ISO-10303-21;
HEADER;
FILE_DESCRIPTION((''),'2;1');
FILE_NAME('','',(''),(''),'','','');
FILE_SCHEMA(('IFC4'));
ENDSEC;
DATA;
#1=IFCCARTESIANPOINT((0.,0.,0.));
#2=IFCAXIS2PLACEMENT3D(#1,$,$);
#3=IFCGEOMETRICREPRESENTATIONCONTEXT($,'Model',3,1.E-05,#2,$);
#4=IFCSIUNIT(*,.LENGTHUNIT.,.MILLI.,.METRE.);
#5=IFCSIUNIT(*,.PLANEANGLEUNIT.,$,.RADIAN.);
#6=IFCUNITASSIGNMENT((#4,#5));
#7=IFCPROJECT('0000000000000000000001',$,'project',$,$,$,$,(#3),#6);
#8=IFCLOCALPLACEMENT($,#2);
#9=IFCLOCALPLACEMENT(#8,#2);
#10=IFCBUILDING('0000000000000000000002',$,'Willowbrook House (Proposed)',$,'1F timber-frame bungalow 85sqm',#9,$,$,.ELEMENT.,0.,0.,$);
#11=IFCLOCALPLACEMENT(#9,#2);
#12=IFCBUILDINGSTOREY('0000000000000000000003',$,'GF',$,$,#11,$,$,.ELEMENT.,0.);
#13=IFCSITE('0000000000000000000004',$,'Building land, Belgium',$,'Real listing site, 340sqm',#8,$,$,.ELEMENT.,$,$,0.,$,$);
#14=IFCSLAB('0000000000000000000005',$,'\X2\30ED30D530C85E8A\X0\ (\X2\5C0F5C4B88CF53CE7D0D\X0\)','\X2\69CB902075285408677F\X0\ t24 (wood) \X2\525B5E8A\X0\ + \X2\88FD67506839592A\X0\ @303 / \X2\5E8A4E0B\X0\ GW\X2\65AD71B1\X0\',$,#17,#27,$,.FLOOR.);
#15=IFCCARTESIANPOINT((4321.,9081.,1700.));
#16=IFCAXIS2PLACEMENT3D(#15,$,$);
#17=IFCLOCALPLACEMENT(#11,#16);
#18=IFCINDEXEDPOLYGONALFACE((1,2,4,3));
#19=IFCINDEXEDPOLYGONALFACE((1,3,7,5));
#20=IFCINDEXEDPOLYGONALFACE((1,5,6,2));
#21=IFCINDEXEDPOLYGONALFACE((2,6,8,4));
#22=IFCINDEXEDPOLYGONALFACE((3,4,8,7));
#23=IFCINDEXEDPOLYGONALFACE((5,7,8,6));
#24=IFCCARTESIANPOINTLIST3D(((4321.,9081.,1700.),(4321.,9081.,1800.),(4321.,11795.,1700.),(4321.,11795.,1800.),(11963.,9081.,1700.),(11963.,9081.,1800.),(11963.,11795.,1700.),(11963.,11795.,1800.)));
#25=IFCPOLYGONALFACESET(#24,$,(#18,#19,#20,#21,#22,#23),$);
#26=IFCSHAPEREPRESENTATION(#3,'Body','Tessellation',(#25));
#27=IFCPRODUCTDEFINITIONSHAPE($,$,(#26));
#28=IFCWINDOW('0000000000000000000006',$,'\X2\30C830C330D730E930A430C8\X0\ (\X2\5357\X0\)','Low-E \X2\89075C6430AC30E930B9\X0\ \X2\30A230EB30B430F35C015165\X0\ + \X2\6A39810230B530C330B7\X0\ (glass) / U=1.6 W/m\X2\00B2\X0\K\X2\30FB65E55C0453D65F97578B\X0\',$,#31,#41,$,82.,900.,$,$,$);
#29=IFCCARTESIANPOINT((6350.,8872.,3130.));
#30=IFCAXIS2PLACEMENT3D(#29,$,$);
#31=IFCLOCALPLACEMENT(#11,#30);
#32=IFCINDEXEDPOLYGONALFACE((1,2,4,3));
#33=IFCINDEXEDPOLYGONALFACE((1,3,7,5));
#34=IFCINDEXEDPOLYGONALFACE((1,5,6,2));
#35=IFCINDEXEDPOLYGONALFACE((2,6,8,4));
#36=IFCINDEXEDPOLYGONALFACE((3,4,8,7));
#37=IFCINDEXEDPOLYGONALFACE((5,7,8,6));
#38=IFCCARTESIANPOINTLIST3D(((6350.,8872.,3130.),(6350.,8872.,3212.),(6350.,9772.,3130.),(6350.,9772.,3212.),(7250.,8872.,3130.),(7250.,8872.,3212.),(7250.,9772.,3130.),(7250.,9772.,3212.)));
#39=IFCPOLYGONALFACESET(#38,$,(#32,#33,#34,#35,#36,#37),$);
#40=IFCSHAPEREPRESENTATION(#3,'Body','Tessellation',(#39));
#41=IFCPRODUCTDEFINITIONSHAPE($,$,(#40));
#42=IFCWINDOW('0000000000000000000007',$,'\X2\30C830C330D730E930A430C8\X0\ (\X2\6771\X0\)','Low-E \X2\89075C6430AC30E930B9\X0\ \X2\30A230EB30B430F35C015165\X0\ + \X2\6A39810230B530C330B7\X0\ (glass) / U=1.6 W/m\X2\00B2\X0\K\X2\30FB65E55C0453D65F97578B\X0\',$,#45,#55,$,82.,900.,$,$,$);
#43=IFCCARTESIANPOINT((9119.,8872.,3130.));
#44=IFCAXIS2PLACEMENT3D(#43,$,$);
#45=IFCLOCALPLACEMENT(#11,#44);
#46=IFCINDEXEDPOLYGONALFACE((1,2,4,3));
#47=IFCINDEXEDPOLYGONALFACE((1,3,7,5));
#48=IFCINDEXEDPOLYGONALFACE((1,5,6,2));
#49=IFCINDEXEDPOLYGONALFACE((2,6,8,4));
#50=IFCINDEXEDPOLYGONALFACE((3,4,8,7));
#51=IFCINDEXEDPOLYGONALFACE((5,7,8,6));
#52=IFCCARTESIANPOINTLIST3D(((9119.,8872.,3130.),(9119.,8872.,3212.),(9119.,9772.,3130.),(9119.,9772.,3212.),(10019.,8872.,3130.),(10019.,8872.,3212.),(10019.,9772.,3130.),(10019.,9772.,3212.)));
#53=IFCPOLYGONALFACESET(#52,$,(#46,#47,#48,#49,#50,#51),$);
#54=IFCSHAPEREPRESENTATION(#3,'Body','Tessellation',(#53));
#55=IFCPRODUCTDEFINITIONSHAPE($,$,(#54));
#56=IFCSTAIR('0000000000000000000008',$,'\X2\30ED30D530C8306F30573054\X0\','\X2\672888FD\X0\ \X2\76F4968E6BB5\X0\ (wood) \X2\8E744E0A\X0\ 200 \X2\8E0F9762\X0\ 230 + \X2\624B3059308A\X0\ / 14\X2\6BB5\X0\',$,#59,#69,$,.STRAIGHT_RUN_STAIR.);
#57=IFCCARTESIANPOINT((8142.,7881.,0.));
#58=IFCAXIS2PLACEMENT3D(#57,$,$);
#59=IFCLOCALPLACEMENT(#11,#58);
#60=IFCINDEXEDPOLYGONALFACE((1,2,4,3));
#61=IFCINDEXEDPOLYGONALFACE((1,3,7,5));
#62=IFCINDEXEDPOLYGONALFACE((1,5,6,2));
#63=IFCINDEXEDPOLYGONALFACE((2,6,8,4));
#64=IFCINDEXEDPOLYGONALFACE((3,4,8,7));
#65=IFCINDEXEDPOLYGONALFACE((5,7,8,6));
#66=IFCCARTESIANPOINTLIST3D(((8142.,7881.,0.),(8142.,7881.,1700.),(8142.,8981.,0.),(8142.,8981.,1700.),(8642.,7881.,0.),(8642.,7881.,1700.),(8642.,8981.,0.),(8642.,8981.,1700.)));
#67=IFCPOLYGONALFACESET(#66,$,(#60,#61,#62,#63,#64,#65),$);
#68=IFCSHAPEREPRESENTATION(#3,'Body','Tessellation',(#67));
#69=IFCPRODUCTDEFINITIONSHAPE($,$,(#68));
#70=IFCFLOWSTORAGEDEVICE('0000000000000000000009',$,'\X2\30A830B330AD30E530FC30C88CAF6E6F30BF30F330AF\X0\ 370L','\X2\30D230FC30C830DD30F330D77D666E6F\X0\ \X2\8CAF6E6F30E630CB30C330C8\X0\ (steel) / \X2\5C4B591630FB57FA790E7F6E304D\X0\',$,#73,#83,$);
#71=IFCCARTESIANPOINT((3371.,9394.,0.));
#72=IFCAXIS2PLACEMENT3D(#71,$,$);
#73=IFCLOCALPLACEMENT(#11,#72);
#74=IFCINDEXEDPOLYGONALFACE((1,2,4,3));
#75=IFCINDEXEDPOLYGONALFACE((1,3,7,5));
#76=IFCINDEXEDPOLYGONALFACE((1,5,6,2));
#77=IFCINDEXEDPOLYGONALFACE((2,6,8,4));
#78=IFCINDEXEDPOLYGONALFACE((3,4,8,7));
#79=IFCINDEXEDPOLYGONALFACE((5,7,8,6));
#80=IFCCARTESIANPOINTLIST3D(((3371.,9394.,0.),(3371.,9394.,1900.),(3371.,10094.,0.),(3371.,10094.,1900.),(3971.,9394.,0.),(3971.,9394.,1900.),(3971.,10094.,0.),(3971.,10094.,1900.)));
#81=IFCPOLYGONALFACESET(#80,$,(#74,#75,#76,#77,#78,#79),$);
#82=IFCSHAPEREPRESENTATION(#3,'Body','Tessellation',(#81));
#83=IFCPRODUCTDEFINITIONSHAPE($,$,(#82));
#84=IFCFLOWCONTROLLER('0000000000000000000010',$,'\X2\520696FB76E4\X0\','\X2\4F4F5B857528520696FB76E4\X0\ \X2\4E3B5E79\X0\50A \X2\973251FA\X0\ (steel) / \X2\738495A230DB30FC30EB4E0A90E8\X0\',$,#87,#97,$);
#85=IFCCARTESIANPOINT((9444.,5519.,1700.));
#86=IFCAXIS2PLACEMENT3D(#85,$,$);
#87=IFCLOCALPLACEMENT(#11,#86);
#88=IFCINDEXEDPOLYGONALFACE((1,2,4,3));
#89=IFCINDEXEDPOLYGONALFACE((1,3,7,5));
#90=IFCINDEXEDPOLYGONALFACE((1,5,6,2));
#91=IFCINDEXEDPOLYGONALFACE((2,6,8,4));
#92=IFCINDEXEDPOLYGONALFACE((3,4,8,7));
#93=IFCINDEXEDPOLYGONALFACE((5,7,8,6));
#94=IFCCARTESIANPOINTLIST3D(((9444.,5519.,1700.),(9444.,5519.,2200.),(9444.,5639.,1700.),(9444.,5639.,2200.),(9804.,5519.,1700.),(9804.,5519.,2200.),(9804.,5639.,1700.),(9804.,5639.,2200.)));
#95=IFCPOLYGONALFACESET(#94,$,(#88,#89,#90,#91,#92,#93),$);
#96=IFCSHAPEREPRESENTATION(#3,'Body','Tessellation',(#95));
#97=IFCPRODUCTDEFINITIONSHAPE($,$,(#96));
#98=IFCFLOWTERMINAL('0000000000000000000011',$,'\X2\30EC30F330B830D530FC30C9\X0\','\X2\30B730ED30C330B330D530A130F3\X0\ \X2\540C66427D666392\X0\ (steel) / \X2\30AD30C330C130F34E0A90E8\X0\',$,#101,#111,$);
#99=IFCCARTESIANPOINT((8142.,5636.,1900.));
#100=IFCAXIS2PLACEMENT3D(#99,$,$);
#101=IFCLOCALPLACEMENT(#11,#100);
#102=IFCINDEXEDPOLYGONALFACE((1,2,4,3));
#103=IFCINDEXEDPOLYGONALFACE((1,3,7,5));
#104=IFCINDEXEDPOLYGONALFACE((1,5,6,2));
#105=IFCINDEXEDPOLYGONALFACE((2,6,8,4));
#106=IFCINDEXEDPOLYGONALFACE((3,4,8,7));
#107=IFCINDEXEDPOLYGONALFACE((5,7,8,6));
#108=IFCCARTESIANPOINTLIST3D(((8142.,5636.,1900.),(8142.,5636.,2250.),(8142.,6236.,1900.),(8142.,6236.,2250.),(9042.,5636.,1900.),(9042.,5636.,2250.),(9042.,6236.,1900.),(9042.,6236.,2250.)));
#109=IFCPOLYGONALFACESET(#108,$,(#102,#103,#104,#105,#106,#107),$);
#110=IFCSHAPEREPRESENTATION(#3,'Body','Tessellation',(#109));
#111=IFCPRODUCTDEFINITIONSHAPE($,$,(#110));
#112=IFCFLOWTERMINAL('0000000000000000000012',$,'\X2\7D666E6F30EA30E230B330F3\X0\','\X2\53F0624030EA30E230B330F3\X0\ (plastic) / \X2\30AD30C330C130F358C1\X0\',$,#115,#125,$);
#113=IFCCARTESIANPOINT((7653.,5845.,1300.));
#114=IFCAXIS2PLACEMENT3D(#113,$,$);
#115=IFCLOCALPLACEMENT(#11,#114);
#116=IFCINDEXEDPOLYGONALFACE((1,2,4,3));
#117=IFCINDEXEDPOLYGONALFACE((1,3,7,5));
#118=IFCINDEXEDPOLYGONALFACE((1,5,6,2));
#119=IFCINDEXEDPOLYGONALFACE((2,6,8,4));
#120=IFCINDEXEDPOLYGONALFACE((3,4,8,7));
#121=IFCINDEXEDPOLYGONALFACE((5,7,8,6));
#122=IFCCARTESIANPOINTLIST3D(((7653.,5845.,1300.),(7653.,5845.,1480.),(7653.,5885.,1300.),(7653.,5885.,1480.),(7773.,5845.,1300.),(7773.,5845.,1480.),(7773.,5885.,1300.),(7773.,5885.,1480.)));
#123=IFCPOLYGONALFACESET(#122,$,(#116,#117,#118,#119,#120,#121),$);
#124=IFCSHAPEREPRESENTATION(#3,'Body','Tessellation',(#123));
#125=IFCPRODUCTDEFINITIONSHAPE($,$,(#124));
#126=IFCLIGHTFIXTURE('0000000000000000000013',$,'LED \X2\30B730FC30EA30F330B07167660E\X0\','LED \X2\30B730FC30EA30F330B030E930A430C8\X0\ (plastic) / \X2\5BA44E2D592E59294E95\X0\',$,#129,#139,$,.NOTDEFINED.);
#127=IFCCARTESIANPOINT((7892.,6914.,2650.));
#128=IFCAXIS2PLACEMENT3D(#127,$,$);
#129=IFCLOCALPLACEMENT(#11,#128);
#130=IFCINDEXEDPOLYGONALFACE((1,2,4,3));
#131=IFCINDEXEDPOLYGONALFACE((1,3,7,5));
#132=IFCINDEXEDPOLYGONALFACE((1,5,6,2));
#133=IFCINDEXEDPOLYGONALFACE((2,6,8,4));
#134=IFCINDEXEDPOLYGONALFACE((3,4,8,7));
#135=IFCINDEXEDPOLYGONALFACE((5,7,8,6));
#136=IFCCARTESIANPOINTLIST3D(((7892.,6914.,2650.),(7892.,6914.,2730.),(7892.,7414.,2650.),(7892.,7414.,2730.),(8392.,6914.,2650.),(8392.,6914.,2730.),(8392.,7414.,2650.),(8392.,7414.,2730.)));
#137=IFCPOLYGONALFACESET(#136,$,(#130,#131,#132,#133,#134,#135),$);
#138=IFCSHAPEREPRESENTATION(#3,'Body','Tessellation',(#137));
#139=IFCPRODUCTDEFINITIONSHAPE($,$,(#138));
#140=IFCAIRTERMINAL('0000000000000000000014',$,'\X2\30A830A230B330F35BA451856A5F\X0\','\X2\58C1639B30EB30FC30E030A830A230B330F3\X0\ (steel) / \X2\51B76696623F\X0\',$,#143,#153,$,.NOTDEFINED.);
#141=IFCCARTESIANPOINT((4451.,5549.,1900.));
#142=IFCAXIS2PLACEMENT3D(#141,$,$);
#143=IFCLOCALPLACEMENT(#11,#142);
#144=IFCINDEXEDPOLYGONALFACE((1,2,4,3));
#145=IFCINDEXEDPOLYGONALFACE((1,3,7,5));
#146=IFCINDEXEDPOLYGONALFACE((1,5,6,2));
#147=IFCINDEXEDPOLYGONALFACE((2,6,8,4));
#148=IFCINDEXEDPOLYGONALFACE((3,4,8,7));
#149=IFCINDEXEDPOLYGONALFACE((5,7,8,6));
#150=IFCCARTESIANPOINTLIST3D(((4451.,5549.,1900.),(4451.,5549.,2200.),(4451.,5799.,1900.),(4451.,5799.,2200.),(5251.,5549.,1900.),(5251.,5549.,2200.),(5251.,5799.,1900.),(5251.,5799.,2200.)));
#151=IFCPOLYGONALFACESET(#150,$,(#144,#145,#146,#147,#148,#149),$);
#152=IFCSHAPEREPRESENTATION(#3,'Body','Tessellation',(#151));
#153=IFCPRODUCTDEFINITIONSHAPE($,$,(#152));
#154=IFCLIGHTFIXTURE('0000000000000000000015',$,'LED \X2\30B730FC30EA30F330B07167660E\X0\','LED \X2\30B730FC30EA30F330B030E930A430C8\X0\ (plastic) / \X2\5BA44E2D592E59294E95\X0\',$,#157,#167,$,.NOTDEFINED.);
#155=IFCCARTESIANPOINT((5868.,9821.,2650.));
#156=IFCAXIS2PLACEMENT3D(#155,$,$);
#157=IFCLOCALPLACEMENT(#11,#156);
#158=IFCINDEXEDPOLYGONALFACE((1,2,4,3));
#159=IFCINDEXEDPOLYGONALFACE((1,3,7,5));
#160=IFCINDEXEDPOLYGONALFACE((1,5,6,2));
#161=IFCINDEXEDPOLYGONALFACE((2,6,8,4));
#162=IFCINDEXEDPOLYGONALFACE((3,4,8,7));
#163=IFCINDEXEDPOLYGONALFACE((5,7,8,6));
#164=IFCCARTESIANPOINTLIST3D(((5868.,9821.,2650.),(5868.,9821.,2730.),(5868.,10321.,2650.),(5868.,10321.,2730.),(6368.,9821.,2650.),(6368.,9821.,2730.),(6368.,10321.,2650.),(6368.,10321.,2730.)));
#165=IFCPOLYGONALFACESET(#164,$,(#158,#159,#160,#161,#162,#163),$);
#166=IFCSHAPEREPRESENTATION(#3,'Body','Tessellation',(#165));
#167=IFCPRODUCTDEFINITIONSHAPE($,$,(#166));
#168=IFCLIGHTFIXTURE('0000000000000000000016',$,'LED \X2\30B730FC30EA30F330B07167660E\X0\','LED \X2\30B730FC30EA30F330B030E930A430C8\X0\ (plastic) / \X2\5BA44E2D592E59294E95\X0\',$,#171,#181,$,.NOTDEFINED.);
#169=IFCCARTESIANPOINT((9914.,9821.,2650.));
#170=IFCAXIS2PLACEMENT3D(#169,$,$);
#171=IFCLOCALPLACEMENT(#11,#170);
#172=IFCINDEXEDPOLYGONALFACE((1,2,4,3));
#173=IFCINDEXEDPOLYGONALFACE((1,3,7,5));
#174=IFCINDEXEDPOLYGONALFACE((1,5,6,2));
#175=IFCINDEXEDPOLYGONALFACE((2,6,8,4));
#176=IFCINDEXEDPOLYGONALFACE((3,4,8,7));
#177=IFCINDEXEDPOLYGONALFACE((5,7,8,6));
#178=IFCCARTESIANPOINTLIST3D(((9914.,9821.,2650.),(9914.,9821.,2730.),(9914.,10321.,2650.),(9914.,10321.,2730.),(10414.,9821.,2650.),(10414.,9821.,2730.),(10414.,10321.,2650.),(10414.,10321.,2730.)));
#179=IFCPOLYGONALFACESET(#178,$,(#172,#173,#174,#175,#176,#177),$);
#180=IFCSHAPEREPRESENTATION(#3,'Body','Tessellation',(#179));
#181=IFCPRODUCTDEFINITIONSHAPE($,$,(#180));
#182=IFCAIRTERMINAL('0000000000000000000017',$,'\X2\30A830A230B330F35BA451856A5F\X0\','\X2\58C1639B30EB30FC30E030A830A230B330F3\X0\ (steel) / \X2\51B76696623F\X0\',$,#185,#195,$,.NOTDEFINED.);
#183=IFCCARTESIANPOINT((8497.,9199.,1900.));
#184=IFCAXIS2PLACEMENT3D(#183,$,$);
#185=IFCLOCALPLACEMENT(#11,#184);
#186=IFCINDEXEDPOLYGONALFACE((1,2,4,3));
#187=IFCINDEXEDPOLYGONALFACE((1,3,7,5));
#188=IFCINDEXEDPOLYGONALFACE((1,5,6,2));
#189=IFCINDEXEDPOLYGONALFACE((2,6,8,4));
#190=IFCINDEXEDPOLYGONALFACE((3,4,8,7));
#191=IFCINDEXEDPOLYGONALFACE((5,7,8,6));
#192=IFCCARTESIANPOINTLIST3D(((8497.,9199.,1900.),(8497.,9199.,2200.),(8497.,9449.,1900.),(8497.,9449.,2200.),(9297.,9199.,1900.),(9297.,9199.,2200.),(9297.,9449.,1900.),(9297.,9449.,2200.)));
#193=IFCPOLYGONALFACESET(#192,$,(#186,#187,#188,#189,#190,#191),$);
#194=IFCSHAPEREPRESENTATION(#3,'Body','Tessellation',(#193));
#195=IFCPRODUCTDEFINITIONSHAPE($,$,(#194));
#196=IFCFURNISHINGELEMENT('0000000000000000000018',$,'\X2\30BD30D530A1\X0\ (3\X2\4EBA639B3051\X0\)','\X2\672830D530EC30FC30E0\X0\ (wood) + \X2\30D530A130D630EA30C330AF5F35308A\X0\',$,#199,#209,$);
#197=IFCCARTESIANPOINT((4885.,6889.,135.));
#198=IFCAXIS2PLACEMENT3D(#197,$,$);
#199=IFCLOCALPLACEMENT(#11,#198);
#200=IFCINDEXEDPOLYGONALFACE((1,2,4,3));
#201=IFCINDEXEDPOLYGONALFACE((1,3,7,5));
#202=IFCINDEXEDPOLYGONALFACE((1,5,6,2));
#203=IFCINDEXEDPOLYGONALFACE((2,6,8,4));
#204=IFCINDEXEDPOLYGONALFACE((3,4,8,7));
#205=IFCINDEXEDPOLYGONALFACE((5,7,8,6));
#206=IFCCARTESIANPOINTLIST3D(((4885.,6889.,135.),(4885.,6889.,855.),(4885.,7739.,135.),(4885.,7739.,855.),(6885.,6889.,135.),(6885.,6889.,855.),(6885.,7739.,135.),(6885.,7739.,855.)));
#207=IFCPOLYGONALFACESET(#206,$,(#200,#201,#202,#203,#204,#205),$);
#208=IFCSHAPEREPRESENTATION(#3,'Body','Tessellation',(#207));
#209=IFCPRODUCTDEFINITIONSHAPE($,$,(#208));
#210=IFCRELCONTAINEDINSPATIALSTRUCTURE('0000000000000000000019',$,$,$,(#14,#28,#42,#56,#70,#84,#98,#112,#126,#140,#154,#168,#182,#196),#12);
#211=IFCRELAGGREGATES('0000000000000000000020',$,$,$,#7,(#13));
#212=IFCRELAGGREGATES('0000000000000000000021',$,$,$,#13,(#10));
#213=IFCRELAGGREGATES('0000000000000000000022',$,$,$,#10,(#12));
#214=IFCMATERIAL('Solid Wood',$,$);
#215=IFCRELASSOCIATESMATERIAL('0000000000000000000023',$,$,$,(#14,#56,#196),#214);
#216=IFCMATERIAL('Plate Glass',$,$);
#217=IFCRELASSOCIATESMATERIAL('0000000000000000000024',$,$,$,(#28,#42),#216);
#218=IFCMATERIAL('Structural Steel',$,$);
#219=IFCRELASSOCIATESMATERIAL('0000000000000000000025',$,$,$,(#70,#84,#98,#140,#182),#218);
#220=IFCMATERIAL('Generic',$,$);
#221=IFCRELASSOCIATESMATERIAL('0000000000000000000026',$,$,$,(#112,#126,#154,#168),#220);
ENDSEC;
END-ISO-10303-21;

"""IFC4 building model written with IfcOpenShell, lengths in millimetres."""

from ifc_helpers import new_model, si_unit, frame, frame_2d, origin, place, context, project, spatial, rectangle, extrude, material, element, save


model = new_model("IFC4")

# Units and contexts
model_context = context("Model", 3, precision=1e-05, world=origin())
ifc_project = project(units=[si_unit("LENGTHUNIT", "METRE", prefix="MILLI"), si_unit("PLANEANGLEUNIT", "RADIAN")], contexts=[model_context])

# Site, building, storey
site_placement = place(None, origin())
site = spatial("IfcSite", under=ifc_project, at=site_placement, Name="Building land, Belgium", ObjectType="Real listing site, 340sqm", CompositionType="ELEMENT", RefElevation=0.0)
building_placement = place(site_placement, origin())
building = spatial("IfcBuilding", under=site, at=building_placement, Name="Willowbrook House (Proposed)", ObjectType="1F timber-frame bungalow 85sqm", CompositionType="ELEMENT", ElevationOfRefHeight=0.0, ElevationOfTerrain=0.0)
storey_placement = place(building_placement, origin())
storey = spatial("IfcBuildingStorey", under=building, at=storey_placement, Name="GF", CompositionType="ELEMENT", Elevation=0.0)

# Shared definitions
ifc_material_1 = material(Name="Solid Wood")

# Slab
slab_placement = place(storey_placement, frame((4321.0, 9081.0, 1700.0)))
element("IfcSlab", 1, at=slab_placement, inside=storey, material=ifc_material_1, Name="ロフト床 (小屋裏収納)", Description="構造用合板 t24 (wood) 剛床 + 製材根太 @303 / 床下 GW断熱", PredefinedType="FLOOR", context=model_context, shape_type="SweptSolid", body=[
    extrude(rectangle(XDim=7642.0, YDim=2714.0, at=frame_2d((3821.0, 1357.0))), frame((4321.0, 9081.0, 1700.0)), (0.0, 0.0, 1.0), 100.0),
])

# Windows
ifc_material_2 = material(Name="Plate Glass")
window_1_placement = place(storey_placement, frame((6350.0, 8872.0, 3130.0)))
element("IfcWindow", 2, at=window_1_placement, inside=storey, material=ifc_material_2, Name="トップライト (南)", Description="Low-E 複層ガラス アルゴン封入 + 樹脂サッシ (glass) / U=1.6 W/m²K・日射取得型", OverallHeight=82.0, OverallWidth=900.0, context=model_context, shape_type="SweptSolid", body=[
    extrude(rectangle(XDim=900.0, YDim=900.0, at=frame_2d((450.0, 450.0))), frame((6350.0, 8872.0, 3130.0)), (0.0, 0.0, 1.0), 82.0),
])
window_2_placement = place(storey_placement, frame((9119.0, 8872.0, 3130.0)))
element("IfcWindow", 3, at=window_2_placement, inside=storey, material=ifc_material_2, Name="トップライト (東)", Description="Low-E 複層ガラス アルゴン封入 + 樹脂サッシ (glass) / U=1.6 W/m²K・日射取得型", OverallHeight=82.0, OverallWidth=900.0, context=model_context, shape_type="SweptSolid", body=[
    extrude(rectangle(XDim=900.0, YDim=900.0, at=frame_2d((450.0, 450.0))), frame((9119.0, 8872.0, 3130.0)), (0.0, 0.0, 1.0), 82.0),
])

# Stair
stair_placement = place(storey_placement, frame((8142.0, 7881.0, 0.0)))
element("IfcStair", 4, at=stair_placement, inside=storey, material=ifc_material_1, Name="ロフトはしご", Description="木製 直階段 (wood) 蹴上 200 踏面 230 + 手すり / 14段", PredefinedType="STRAIGHT_RUN_STAIR", context=model_context, shape_type="SweptSolid", body=[
    extrude(rectangle(XDim=500.0, YDim=1100.0, at=frame_2d((250.0, 550.0))), frame((8142.0, 7881.0, 0.0)), (0.0, 0.0, 1.0), 1700.0),
])

# Flow storage device
ifc_material_3 = material(Name="Structural Steel")
flow_storage_device_placement = place(storey_placement, frame((3371.0, 9394.0, 0.0)))
element("IfcFlowStorageDevice", 5, at=flow_storage_device_placement, inside=storey, material=ifc_material_3, Name="エコキュート貯湯タンク 370L", Description="ヒートポンプ給湯 貯湯ユニット (steel) / 屋外・基礎置き", context=model_context, shape_type="SweptSolid", body=[
    extrude(rectangle(XDim=600.0, YDim=700.0, at=frame_2d((300.0, 350.0))), frame((3371.0, 9394.0, 0.0)), (0.0, 0.0, 1.0), 1900.0),
])

# Flow controller
flow_controller_placement = place(storey_placement, frame((9444.0, 5519.0, 1700.0)))
element("IfcFlowController", 6, at=flow_controller_placement, inside=storey, material=ifc_material_3, Name="分電盤", Description="住宅用分電盤 主幹50A 露出 (steel) / 玄関ホール上部", context=model_context, shape_type="SweptSolid", body=[
    extrude(rectangle(XDim=360.0, YDim=120.0, at=frame_2d((180.0, 60.0))), frame((9444.0, 5519.0, 1700.0)), (0.0, 0.0, 1.0), 500.0),
])

# Flow terminals
flow_terminal_1_placement = place(storey_placement, frame((8142.0, 5636.0, 1900.0)))
element("IfcFlowTerminal", 7, at=flow_terminal_1_placement, inside=storey, material=ifc_material_3, Name="レンジフード", Description="シロッコファン 同時給排 (steel) / キッチン上部", context=model_context, shape_type="SweptSolid", body=[
    extrude(rectangle(XDim=900.0, YDim=600.0, at=frame_2d((450.0, 300.0))), frame((8142.0, 5636.0, 1900.0)), (0.0, 0.0, 1.0), 350.0),
])
ifc_material_4 = material(Name="Generic")
flow_terminal_2_placement = place(storey_placement, frame((7653.0, 5845.0, 1300.0)))
element("IfcFlowTerminal", 8, at=flow_terminal_2_placement, inside=storey, material=ifc_material_4, Name="給湯リモコン", Description="台所リモコン (plastic) / キッチン壁", context=model_context, shape_type="SweptSolid", body=[
    extrude(rectangle(XDim=120.0, YDim=40.0, at=frame_2d((60.0, 20.0))), frame((7653.0, 5845.0, 1300.0)), (0.0, 0.0, 1.0), 180.0),
])

# Light fixture
light_fixture_1_placement = place(storey_placement, frame((7892.0, 6914.0, 2650.0)))
element("IfcLightFixture", 9, at=light_fixture_1_placement, inside=storey, material=ifc_material_4, Name="LED シーリング照明", Description="LED シーリングライト (plastic) / 室中央天井", PredefinedType="NOTDEFINED", context=model_context, shape_type="SweptSolid", body=[
    extrude(rectangle(XDim=500.0, YDim=500.0, at=frame_2d((250.0, 250.0))), frame((7892.0, 6914.0, 2650.0)), (0.0, 0.0, 1.0), 80.0),
])

# Air terminal
air_terminal_1_placement = place(storey_placement, frame((4451.0, 5549.0, 1900.0)))
element("IfcAirTerminal", 10, at=air_terminal_1_placement, inside=storey, material=ifc_material_3, Name="エアコン室内機", Description="壁掛ルームエアコン (steel) / 冷暖房", PredefinedType="NOTDEFINED", context=model_context, shape_type="SweptSolid", body=[
    extrude(rectangle(XDim=800.0, YDim=250.0, at=frame_2d((400.0, 125.0))), frame((4451.0, 5549.0, 1900.0)), (0.0, 0.0, 1.0), 300.0),
])

# Light fixtures
light_fixture_2_placement = place(storey_placement, frame((5868.0, 9821.0, 2650.0)))
element("IfcLightFixture", 11, at=light_fixture_2_placement, inside=storey, material=ifc_material_4, Name="LED シーリング照明", Description="LED シーリングライト (plastic) / 室中央天井", PredefinedType="NOTDEFINED", context=model_context, shape_type="SweptSolid", body=[
    extrude(rectangle(XDim=500.0, YDim=500.0, at=frame_2d((250.0, 250.0))), frame((5868.0, 9821.0, 2650.0)), (0.0, 0.0, 1.0), 80.0),
])
light_fixture_3_placement = place(storey_placement, frame((9914.0, 9821.0, 2650.0)))
element("IfcLightFixture", 12, at=light_fixture_3_placement, inside=storey, material=ifc_material_4, Name="LED シーリング照明", Description="LED シーリングライト (plastic) / 室中央天井", PredefinedType="NOTDEFINED", context=model_context, shape_type="SweptSolid", body=[
    extrude(rectangle(XDim=500.0, YDim=500.0, at=frame_2d((250.0, 250.0))), frame((9914.0, 9821.0, 2650.0)), (0.0, 0.0, 1.0), 80.0),
])

# Air terminal
air_terminal_2_placement = place(storey_placement, frame((8497.0, 9199.0, 1900.0)))
element("IfcAirTerminal", 13, at=air_terminal_2_placement, inside=storey, material=ifc_material_3, Name="エアコン室内機", Description="壁掛ルームエアコン (steel) / 冷暖房", PredefinedType="NOTDEFINED", context=model_context, shape_type="SweptSolid", body=[
    extrude(rectangle(XDim=800.0, YDim=250.0, at=frame_2d((400.0, 125.0))), frame((8497.0, 9199.0, 1900.0)), (0.0, 0.0, 1.0), 300.0),
])

# Furnishing element
furnishing_1_placement = place(storey_placement, frame((4885.0, 6889.0, 135.0)))
element("IfcFurnishingElement", 14, at=furnishing_1_placement, inside=storey, material=ifc_material_1, Name="ソファ (3人掛け)", Description="木フレーム (wood) + ファブリック張り", context=model_context, shape_type="SweptSolid", body=[
    extrude(rectangle(XDim=2000.0, YDim=850.0, at=frame_2d((1000.0, 425.0))), frame((4885.0, 6889.0, 135.0)), (0.0, 0.0, 1.0), 720.0),
])

save(model, "model.ifc")
